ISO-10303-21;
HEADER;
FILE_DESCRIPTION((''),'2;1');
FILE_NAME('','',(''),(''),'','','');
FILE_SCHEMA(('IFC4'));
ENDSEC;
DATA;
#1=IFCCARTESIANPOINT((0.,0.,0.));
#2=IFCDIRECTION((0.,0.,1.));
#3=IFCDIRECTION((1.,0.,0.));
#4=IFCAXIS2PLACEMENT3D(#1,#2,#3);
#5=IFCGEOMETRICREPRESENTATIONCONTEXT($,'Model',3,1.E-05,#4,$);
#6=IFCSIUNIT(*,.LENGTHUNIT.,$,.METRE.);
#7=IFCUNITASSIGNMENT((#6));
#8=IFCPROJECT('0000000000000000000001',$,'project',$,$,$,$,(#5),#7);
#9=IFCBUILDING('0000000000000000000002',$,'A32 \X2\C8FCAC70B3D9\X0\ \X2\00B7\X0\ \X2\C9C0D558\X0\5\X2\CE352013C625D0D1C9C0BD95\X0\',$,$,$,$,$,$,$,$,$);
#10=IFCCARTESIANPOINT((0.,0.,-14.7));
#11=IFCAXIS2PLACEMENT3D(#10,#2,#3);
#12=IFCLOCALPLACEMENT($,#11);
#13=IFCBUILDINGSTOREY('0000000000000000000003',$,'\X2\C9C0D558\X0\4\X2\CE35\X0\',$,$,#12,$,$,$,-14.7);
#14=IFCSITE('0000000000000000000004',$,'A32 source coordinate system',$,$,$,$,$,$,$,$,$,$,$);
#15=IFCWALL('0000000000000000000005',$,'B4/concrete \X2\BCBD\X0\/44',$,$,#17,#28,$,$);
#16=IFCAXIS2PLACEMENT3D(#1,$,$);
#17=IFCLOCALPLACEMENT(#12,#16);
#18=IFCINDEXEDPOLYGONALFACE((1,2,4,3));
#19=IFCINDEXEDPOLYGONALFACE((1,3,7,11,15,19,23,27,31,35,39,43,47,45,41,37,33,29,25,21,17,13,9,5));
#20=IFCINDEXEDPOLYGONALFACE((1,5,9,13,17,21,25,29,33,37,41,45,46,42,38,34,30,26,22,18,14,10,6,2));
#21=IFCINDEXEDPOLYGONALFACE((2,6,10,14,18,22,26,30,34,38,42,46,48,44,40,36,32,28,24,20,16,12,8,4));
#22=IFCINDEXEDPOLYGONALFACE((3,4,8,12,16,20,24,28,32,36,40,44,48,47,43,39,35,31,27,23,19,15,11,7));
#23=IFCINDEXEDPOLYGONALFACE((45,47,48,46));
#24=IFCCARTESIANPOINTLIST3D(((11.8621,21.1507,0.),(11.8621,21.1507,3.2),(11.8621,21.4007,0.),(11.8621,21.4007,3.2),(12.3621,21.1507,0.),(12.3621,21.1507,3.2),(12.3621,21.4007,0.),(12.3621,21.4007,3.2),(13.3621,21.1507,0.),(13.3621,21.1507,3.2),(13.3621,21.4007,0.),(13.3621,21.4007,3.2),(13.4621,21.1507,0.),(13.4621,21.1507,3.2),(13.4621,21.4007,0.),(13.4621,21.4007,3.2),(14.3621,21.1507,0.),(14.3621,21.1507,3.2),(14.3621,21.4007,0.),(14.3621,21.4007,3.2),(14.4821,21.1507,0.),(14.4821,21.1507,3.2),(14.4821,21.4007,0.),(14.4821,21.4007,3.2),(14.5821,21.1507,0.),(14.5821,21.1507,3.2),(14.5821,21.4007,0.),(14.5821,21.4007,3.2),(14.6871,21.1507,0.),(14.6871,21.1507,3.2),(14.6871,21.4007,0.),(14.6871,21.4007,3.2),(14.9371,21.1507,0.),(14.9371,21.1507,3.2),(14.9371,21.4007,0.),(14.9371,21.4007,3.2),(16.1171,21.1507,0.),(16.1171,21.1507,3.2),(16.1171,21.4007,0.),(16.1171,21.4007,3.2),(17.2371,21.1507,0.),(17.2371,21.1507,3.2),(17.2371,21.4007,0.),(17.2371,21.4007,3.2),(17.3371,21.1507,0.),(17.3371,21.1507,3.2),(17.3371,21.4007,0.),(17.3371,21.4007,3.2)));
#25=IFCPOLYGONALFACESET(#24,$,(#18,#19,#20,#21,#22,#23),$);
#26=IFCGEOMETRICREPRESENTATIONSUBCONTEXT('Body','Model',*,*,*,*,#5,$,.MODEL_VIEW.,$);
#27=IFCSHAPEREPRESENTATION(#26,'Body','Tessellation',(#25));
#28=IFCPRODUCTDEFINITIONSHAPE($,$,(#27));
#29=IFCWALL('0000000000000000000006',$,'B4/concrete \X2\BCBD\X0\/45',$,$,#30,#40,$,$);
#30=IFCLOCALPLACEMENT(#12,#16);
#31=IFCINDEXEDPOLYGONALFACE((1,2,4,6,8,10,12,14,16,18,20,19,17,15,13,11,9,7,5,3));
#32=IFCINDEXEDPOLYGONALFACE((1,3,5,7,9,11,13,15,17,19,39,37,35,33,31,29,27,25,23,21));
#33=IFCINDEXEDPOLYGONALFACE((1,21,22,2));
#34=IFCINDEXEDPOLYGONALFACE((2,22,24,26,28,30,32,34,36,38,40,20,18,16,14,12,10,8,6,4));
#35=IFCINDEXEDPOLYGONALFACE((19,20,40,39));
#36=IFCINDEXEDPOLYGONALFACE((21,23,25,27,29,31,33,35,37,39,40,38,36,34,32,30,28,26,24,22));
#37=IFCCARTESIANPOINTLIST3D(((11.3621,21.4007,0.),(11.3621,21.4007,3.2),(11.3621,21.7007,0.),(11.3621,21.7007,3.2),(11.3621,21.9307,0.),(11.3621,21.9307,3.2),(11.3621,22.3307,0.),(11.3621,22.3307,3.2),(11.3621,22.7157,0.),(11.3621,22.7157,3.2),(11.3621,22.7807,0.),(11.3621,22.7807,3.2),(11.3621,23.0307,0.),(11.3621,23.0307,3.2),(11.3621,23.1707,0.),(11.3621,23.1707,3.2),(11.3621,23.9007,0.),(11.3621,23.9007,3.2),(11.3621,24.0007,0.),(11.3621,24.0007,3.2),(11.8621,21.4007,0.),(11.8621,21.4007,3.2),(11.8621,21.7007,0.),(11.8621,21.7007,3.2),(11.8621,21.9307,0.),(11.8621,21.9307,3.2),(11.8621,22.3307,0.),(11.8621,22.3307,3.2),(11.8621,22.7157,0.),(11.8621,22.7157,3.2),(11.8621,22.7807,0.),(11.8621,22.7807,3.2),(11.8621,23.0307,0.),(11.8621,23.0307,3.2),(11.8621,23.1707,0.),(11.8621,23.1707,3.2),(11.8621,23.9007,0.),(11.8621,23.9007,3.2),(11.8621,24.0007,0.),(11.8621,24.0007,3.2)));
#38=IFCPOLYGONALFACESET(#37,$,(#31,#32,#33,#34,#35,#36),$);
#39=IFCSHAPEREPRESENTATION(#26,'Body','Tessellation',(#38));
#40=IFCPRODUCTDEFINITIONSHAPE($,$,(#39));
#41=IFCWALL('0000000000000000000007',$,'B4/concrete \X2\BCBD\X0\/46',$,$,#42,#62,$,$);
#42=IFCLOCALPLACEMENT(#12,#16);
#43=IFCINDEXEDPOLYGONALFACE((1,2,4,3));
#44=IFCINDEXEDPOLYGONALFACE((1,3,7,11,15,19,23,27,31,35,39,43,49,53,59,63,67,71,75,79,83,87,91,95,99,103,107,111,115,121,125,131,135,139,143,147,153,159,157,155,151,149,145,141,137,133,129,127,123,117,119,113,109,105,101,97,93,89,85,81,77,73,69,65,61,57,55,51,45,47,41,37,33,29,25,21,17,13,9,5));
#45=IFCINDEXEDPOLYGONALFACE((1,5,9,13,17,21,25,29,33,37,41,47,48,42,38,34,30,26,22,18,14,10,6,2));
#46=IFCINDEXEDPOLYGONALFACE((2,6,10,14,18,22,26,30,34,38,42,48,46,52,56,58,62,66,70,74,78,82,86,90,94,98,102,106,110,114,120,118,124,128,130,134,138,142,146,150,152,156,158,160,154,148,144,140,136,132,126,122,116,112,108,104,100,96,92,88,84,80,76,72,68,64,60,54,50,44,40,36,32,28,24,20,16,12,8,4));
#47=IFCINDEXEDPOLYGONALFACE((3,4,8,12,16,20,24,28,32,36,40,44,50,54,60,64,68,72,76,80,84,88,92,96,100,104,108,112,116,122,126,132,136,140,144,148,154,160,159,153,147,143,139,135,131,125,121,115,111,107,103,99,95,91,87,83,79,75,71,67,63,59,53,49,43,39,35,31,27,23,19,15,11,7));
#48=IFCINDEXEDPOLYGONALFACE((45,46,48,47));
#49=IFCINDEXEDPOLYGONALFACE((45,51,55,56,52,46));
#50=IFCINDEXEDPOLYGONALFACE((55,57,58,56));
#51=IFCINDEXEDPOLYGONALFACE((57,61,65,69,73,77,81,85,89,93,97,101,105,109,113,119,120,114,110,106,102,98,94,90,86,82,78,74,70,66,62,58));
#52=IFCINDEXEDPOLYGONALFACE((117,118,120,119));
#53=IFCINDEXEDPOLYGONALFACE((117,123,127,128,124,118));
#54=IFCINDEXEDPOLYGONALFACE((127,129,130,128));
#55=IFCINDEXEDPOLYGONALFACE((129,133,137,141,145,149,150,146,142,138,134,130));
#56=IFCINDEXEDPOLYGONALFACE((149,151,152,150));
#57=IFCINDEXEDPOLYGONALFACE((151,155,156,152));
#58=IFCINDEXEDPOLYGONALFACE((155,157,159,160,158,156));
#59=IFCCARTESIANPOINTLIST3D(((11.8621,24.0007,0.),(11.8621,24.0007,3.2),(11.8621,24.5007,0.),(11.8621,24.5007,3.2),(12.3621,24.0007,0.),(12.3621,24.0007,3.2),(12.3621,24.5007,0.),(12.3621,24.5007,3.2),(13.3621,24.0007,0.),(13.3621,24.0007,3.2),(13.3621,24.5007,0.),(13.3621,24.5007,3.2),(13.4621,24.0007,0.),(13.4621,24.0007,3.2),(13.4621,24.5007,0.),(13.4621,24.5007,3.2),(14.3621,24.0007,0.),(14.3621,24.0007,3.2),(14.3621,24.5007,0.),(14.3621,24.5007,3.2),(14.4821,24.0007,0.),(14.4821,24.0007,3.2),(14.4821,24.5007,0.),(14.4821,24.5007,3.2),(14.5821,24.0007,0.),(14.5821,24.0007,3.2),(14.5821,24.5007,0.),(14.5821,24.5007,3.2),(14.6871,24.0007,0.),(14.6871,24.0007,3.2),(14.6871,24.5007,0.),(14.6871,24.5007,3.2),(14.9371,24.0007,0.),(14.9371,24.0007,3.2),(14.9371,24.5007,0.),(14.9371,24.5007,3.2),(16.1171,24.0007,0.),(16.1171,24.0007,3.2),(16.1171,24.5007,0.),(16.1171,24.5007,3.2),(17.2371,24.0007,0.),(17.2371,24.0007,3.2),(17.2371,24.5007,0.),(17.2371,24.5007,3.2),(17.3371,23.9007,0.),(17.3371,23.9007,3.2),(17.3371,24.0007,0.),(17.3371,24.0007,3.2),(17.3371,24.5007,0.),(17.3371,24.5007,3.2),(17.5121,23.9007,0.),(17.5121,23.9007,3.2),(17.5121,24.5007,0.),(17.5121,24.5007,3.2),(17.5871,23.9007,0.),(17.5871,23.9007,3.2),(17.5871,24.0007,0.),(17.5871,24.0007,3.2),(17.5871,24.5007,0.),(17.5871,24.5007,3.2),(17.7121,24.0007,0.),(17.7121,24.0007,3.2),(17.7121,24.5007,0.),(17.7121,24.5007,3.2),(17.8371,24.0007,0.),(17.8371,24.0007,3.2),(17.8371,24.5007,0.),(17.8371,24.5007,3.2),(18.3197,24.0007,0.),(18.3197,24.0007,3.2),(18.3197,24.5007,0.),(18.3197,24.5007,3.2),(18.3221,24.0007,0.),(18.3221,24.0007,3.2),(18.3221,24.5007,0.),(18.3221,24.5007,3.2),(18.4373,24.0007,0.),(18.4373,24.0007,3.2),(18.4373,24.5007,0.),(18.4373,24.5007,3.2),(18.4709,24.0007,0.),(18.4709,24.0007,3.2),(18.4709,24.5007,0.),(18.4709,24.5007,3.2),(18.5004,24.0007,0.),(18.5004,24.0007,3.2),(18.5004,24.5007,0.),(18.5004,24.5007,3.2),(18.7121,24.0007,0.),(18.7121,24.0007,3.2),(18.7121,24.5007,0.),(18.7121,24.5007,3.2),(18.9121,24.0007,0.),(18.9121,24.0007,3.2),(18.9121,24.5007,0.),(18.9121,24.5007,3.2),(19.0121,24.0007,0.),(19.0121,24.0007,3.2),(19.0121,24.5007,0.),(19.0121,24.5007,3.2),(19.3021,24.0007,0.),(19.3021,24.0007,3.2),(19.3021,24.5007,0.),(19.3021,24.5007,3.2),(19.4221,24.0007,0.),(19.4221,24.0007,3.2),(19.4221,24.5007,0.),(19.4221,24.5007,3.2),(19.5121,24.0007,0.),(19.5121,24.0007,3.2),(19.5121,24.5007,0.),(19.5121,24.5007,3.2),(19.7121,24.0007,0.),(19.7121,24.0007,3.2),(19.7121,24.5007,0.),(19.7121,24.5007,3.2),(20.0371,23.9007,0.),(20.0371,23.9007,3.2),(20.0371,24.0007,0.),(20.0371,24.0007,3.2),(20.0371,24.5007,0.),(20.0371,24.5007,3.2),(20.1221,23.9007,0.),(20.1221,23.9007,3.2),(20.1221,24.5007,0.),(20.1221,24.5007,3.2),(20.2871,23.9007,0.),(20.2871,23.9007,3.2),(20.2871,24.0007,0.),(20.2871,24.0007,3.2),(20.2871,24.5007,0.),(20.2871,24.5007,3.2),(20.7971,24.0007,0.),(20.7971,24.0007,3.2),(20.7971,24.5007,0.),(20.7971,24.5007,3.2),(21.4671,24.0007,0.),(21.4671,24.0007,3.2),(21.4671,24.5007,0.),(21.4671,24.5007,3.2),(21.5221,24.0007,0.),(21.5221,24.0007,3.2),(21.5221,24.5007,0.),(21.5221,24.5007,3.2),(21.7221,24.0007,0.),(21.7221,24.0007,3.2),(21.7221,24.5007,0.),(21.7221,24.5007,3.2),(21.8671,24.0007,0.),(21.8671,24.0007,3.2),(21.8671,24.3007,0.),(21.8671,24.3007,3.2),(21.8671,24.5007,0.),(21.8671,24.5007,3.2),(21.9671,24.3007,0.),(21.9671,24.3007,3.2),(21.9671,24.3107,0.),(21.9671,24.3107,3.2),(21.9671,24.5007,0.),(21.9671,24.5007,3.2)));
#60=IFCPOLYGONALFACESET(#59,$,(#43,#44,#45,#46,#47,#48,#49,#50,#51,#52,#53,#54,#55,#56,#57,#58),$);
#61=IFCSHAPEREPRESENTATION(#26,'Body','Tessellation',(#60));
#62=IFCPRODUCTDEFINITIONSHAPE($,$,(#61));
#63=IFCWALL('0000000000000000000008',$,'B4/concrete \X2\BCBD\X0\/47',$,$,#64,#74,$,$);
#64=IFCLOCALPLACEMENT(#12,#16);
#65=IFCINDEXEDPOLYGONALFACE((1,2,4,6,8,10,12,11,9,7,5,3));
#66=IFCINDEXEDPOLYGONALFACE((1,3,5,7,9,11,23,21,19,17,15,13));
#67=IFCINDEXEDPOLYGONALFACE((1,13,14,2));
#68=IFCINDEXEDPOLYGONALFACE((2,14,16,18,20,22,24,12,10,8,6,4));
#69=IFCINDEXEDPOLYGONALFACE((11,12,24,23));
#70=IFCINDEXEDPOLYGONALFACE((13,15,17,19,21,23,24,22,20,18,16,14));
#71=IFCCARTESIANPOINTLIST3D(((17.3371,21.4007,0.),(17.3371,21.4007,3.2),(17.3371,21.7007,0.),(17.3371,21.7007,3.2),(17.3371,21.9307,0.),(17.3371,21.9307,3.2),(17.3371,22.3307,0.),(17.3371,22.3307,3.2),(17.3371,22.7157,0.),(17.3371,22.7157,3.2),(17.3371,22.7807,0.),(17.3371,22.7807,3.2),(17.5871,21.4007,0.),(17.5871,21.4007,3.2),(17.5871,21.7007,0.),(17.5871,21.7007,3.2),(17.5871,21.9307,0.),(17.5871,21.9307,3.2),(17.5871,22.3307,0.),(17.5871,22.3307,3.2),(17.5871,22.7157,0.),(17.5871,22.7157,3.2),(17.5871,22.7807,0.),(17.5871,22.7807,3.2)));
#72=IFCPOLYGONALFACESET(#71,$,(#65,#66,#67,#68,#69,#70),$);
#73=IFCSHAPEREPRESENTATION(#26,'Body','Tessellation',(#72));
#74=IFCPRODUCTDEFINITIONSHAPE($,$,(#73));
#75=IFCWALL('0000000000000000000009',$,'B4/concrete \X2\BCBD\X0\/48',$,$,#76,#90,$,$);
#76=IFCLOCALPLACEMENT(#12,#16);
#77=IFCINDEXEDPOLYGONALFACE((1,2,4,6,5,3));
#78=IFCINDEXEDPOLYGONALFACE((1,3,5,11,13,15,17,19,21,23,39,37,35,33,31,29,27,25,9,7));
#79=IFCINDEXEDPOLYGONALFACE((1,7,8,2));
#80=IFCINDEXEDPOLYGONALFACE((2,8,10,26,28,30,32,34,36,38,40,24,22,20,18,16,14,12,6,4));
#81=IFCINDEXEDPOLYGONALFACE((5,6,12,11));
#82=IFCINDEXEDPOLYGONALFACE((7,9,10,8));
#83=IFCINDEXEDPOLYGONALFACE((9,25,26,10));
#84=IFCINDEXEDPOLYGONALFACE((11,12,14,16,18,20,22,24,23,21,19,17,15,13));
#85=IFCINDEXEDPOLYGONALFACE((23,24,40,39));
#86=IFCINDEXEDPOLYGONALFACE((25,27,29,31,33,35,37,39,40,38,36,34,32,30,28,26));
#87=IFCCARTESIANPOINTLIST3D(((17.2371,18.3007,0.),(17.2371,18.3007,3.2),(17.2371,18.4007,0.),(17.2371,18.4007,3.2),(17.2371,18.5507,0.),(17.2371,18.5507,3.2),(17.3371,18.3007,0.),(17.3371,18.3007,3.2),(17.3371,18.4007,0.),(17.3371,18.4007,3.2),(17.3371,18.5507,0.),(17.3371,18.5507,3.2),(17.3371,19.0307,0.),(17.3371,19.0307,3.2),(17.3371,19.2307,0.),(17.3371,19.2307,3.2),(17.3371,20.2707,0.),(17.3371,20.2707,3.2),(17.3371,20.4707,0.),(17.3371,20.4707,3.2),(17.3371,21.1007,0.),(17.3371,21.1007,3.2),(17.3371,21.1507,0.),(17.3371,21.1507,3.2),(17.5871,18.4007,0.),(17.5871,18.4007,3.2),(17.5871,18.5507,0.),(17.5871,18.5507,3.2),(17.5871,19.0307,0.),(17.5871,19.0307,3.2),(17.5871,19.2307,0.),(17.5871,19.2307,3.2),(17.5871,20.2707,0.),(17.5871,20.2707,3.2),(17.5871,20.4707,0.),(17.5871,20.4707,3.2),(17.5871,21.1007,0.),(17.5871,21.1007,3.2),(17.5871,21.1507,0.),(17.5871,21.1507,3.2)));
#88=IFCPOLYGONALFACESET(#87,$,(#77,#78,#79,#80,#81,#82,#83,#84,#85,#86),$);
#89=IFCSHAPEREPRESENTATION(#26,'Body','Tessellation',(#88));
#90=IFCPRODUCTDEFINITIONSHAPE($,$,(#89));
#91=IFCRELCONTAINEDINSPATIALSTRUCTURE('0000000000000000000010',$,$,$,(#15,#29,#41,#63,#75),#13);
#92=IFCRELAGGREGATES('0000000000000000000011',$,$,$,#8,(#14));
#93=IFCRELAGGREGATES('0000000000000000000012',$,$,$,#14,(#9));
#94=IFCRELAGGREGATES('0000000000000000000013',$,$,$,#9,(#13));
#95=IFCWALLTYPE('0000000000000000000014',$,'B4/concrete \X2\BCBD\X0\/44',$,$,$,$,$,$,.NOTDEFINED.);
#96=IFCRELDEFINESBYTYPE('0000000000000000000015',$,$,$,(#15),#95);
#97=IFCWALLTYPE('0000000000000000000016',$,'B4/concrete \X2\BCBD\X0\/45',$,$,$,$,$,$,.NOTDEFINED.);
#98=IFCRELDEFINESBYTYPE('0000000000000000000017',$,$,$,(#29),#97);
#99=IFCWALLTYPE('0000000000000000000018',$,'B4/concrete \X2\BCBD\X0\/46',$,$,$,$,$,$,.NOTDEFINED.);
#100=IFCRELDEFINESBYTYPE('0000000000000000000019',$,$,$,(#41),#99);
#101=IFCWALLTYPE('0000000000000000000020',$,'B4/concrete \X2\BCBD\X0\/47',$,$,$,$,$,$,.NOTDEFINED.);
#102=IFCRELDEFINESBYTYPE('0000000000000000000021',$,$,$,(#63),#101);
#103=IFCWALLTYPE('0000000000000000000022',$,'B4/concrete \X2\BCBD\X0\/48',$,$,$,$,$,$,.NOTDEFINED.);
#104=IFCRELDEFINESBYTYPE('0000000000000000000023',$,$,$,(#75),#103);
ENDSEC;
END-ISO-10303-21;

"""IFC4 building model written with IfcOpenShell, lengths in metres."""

from ifc_helpers import new_model, si_unit, frame, origin, origin_with_axes, place, context, subcontext, project, spatial, polyline, outline, extrude, source, transform, mapped, type_object, type_shapes, element, save


model = new_model("IFC4")

# Units and contexts
model_context = context("Model", 3, precision=1e-05, world=origin_with_axes())
body_context = subcontext(model_context, "Body", "Model", "MODEL_VIEW")
ifc_project = project(units=[si_unit("LENGTHUNIT", "METRE")], contexts=[model_context])

# Site, building, storey
site = spatial("IfcSite", under=ifc_project, Name="A32 source coordinate system")
building = spatial("IfcBuilding", under=site, Name="A32 주거동 · 지하5층–옥탑지붕")
storey_placement = place(None, frame((0.0, 0.0, -14.7), z_axis=(0.0, 0.0, 1.0), x_axis=(1.0, 0.0, 0.0)))
storey = spatial("IfcBuildingStorey", under=building, at=storey_placement, Name="지하4층", Elevation=-14.7)

# Walls
wall_type_1 = type_object("IfcWallType", Name="B4/concrete 벽/44", PredefinedType="NOTDEFINED")
shared_shape_1 = source(origin(), body_context, "Body", "SweptSolid", [
    extrude(outline(polyline([(13.3621, 21.4007), (13.4621, 21.4007), (14.3621, 21.4007), (14.4821, 21.4007), (14.5821, 21.4007), (14.6871, 21.4007), (14.9371, 21.4007), (16.1171, 21.4007), (17.2371, 21.4007), (17.3371, 21.4007), (17.3371, 21.1507), (17.2371, 21.1507), (16.1171, 21.1507), (14.9371, 21.1507), (14.6871, 21.1507), (14.5821, 21.1507), (14.4821, 21.1507), (14.3621, 21.1507), (13.4621, 21.1507), (13.3621, 21.1507), (12.3621, 21.1507), (11.8621, 21.1507), (11.8621, 21.4007), (12.3621, 21.4007), (13.3621, 21.4007)])), origin(), (0.0, 0.0, 1.0), 3.2),
])
type_shapes(wall_type_1, [shared_shape_1])
wall_1_placement = place(storey_placement, origin_with_axes())
element("IfcWall", 1, at=wall_1_placement, inside=storey, type_object=wall_type_1, Name="B4/concrete 벽/44", context=body_context, shape_type="MappedRepresentation", body=[
    mapped(shared_shape_1, transform((0.0, 0.0, 0.0), scale=1.0)),
])
wall_type_2 = type_object("IfcWallType", Name="B4/concrete 벽/45", PredefinedType="NOTDEFINED")
shared_shape_2 = source(origin(), body_context, "Body", "SweptSolid", [
    extrude(outline(polyline([(11.3621, 21.9307), (11.3621, 22.3307), (11.3621, 22.7157), (11.3621, 22.7807), (11.3621, 23.0307), (11.3621, 23.1707), (11.3621, 23.9007), (11.3621, 24.0007), (11.8621, 24.0007), (11.8621, 23.9007), (11.8621, 23.1707), (11.8621, 23.0307), (11.8621, 22.7807), (11.8621, 22.7157), (11.8621, 22.3307), (11.8621, 21.9307), (11.8621, 21.7007), (11.8621, 21.4007), (11.3621, 21.4007), (11.3621, 21.7007), (11.3621, 21.9307)])), origin(), (0.0, 0.0, 1.0), 3.2),
])
type_shapes(wall_type_2, [shared_shape_2])
wall_2_placement = place(storey_placement, origin_with_axes())
element("IfcWall", 2, at=wall_2_placement, inside=storey, type_object=wall_type_2, Name="B4/concrete 벽/45", context=body_context, shape_type="MappedRepresentation", body=[
    mapped(shared_shape_2, transform((0.0, 0.0, 0.0), scale=1.0)),
])
wall_type_3 = type_object("IfcWallType", Name="B4/concrete 벽/46", PredefinedType="NOTDEFINED")
shared_shape_3 = source(origin(), body_context, "Body", "SweptSolid", [
    extrude(outline(polyline([(13.3621, 24.5007), (13.4621, 24.5007), (14.3621, 24.5007), (14.4821, 24.5007), (14.5821, 24.5007), (14.6871, 24.5007), (14.9371, 24.5007), (16.1171, 24.5007), (17.2371, 24.5007), (17.3371, 24.5007), (17.5121, 24.5007), (17.5871, 24.5007), (17.7121, 24.5007), (17.8371, 24.5007), (18.3197, 24.5007), (18.3221, 24.5007), (18.4373, 24.5007), (18.4709, 24.5007), (18.5004, 24.5007), (18.7121, 24.5007), (18.9121, 24.5007), (19.0121, 24.5007), (19.3021, 24.5007), (19.4221, 24.5007), (19.5121, 24.5007), (19.7121, 24.5007), (20.0371, 24.5007), (20.1221, 24.5007), (20.2871, 24.5007), (20.7971, 24.5007), (21.4671, 24.5007), (21.5221, 24.5007), (21.7221, 24.5007), (21.8671, 24.5007), (21.9671, 24.5007), (21.9671, 24.3107), (21.9671, 24.3007), (21.8671, 24.3007), (21.8671, 24.0007), (21.7221, 24.0007), (21.5221, 24.0007), (21.4671, 24.0007), (20.7971, 24.0007), (20.2871, 24.0007), (20.2871, 23.9007), (20.1221, 23.9007), (20.0371, 23.9007), (20.0371, 24.0007), (19.7121, 24.0007), (19.5121, 24.0007), (19.4221, 24.0007), (19.3021, 24.0007), (19.0121, 24.0007), (18.9121, 24.0007), (18.7121, 24.0007), (18.5004, 24.0007), (18.4709, 24.0007), (18.4373, 24.0007), (18.3221, 24.0007), (18.3197, 24.0007), (17.8371, 24.0007), (17.7121, 24.0007), (17.5871, 24.0007), (17.5871, 23.9007), (17.5121, 23.9007), (17.3371, 23.9007), (17.3371, 24.0007), (17.2371, 24.0007), (16.1171, 24.0007), (14.9371, 24.0007), (14.6871, 24.0007), (14.5821, 24.0007), (14.4821, 24.0007), (14.3621, 24.0007), (13.4621, 24.0007), (13.3621, 24.0007), (12.3621, 24.0007), (11.8621, 24.0007), (11.8621, 24.5007), (12.3621, 24.5007), (13.3621, 24.5007)])), origin(), (0.0, 0.0, 1.0), 3.2),
])
type_shapes(wall_type_3, [shared_shape_3])
wall_3_placement = place(storey_placement, origin_with_axes())
element("IfcWall", 3, at=wall_3_placement, inside=storey, type_object=wall_type_3, Name="B4/concrete 벽/46", context=body_context, shape_type="MappedRepresentation", body=[
    mapped(shared_shape_3, transform((0.0, 0.0, 0.0), scale=1.0)),
])
wall_type_4 = type_object("IfcWallType", Name="B4/concrete 벽/47", PredefinedType="NOTDEFINED")
shared_shape_4 = source(origin(), body_context, "Body", "SweptSolid", [
    extrude(outline(polyline([(17.3371, 22.3307), (17.3371, 22.7157), (17.3371, 22.7807), (17.5871, 22.7807), (17.5871, 22.7157), (17.5871, 22.3307), (17.5871, 21.9307), (17.5871, 21.7007), (17.5871, 21.4007), (17.3371, 21.4007), (17.3371, 21.7007), (17.3371, 21.9307), (17.3371, 22.3307)])), origin(), (0.0, 0.0, 1.0), 3.2),
])
type_shapes(wall_type_4, [shared_shape_4])
wall_4_placement = place(storey_placement, origin_with_axes())
element("IfcWall", 4, at=wall_4_placement, inside=storey, type_object=wall_type_4, Name="B4/concrete 벽/47", context=body_context, shape_type="MappedRepresentation", body=[
    mapped(shared_shape_4, transform((0.0, 0.0, 0.0), scale=1.0)),
])
wall_type_5 = type_object("IfcWallType", Name="B4/concrete 벽/48", PredefinedType="NOTDEFINED")
shared_shape_5 = source(origin(), body_context, "Body", "SweptSolid", [
    extrude(outline(polyline([(17.5871, 20.4707), (17.5871, 20.2707), (17.5871, 19.2307), (17.5871, 19.0307), (17.5871, 18.5507), (17.5871, 18.4007), (17.3371, 18.4007), (17.3371, 18.3007), (17.2371, 18.3007), (17.2371, 18.4007), (17.2371, 18.5507), (17.3371, 18.5507), (17.3371, 19.0307), (17.3371, 19.2307), (17.3371, 20.2707), (17.3371, 20.4707), (17.3371, 21.1007), (17.3371, 21.1507), (17.5871, 21.1507), (17.5871, 21.1007), (17.5871, 20.4707)])), origin(), (0.0, 0.0, 1.0), 3.2),
])
type_shapes(wall_type_5, [shared_shape_5])
wall_5_placement = place(storey_placement, origin_with_axes())
element("IfcWall", 5, at=wall_5_placement, inside=storey, type_object=wall_type_5, Name="B4/concrete 벽/48", context=body_context, shape_type="MappedRepresentation", body=[
    mapped(shared_shape_5, transform((0.0, 0.0, 0.0), scale=1.0)),
])

save(model, "model.ifc")
